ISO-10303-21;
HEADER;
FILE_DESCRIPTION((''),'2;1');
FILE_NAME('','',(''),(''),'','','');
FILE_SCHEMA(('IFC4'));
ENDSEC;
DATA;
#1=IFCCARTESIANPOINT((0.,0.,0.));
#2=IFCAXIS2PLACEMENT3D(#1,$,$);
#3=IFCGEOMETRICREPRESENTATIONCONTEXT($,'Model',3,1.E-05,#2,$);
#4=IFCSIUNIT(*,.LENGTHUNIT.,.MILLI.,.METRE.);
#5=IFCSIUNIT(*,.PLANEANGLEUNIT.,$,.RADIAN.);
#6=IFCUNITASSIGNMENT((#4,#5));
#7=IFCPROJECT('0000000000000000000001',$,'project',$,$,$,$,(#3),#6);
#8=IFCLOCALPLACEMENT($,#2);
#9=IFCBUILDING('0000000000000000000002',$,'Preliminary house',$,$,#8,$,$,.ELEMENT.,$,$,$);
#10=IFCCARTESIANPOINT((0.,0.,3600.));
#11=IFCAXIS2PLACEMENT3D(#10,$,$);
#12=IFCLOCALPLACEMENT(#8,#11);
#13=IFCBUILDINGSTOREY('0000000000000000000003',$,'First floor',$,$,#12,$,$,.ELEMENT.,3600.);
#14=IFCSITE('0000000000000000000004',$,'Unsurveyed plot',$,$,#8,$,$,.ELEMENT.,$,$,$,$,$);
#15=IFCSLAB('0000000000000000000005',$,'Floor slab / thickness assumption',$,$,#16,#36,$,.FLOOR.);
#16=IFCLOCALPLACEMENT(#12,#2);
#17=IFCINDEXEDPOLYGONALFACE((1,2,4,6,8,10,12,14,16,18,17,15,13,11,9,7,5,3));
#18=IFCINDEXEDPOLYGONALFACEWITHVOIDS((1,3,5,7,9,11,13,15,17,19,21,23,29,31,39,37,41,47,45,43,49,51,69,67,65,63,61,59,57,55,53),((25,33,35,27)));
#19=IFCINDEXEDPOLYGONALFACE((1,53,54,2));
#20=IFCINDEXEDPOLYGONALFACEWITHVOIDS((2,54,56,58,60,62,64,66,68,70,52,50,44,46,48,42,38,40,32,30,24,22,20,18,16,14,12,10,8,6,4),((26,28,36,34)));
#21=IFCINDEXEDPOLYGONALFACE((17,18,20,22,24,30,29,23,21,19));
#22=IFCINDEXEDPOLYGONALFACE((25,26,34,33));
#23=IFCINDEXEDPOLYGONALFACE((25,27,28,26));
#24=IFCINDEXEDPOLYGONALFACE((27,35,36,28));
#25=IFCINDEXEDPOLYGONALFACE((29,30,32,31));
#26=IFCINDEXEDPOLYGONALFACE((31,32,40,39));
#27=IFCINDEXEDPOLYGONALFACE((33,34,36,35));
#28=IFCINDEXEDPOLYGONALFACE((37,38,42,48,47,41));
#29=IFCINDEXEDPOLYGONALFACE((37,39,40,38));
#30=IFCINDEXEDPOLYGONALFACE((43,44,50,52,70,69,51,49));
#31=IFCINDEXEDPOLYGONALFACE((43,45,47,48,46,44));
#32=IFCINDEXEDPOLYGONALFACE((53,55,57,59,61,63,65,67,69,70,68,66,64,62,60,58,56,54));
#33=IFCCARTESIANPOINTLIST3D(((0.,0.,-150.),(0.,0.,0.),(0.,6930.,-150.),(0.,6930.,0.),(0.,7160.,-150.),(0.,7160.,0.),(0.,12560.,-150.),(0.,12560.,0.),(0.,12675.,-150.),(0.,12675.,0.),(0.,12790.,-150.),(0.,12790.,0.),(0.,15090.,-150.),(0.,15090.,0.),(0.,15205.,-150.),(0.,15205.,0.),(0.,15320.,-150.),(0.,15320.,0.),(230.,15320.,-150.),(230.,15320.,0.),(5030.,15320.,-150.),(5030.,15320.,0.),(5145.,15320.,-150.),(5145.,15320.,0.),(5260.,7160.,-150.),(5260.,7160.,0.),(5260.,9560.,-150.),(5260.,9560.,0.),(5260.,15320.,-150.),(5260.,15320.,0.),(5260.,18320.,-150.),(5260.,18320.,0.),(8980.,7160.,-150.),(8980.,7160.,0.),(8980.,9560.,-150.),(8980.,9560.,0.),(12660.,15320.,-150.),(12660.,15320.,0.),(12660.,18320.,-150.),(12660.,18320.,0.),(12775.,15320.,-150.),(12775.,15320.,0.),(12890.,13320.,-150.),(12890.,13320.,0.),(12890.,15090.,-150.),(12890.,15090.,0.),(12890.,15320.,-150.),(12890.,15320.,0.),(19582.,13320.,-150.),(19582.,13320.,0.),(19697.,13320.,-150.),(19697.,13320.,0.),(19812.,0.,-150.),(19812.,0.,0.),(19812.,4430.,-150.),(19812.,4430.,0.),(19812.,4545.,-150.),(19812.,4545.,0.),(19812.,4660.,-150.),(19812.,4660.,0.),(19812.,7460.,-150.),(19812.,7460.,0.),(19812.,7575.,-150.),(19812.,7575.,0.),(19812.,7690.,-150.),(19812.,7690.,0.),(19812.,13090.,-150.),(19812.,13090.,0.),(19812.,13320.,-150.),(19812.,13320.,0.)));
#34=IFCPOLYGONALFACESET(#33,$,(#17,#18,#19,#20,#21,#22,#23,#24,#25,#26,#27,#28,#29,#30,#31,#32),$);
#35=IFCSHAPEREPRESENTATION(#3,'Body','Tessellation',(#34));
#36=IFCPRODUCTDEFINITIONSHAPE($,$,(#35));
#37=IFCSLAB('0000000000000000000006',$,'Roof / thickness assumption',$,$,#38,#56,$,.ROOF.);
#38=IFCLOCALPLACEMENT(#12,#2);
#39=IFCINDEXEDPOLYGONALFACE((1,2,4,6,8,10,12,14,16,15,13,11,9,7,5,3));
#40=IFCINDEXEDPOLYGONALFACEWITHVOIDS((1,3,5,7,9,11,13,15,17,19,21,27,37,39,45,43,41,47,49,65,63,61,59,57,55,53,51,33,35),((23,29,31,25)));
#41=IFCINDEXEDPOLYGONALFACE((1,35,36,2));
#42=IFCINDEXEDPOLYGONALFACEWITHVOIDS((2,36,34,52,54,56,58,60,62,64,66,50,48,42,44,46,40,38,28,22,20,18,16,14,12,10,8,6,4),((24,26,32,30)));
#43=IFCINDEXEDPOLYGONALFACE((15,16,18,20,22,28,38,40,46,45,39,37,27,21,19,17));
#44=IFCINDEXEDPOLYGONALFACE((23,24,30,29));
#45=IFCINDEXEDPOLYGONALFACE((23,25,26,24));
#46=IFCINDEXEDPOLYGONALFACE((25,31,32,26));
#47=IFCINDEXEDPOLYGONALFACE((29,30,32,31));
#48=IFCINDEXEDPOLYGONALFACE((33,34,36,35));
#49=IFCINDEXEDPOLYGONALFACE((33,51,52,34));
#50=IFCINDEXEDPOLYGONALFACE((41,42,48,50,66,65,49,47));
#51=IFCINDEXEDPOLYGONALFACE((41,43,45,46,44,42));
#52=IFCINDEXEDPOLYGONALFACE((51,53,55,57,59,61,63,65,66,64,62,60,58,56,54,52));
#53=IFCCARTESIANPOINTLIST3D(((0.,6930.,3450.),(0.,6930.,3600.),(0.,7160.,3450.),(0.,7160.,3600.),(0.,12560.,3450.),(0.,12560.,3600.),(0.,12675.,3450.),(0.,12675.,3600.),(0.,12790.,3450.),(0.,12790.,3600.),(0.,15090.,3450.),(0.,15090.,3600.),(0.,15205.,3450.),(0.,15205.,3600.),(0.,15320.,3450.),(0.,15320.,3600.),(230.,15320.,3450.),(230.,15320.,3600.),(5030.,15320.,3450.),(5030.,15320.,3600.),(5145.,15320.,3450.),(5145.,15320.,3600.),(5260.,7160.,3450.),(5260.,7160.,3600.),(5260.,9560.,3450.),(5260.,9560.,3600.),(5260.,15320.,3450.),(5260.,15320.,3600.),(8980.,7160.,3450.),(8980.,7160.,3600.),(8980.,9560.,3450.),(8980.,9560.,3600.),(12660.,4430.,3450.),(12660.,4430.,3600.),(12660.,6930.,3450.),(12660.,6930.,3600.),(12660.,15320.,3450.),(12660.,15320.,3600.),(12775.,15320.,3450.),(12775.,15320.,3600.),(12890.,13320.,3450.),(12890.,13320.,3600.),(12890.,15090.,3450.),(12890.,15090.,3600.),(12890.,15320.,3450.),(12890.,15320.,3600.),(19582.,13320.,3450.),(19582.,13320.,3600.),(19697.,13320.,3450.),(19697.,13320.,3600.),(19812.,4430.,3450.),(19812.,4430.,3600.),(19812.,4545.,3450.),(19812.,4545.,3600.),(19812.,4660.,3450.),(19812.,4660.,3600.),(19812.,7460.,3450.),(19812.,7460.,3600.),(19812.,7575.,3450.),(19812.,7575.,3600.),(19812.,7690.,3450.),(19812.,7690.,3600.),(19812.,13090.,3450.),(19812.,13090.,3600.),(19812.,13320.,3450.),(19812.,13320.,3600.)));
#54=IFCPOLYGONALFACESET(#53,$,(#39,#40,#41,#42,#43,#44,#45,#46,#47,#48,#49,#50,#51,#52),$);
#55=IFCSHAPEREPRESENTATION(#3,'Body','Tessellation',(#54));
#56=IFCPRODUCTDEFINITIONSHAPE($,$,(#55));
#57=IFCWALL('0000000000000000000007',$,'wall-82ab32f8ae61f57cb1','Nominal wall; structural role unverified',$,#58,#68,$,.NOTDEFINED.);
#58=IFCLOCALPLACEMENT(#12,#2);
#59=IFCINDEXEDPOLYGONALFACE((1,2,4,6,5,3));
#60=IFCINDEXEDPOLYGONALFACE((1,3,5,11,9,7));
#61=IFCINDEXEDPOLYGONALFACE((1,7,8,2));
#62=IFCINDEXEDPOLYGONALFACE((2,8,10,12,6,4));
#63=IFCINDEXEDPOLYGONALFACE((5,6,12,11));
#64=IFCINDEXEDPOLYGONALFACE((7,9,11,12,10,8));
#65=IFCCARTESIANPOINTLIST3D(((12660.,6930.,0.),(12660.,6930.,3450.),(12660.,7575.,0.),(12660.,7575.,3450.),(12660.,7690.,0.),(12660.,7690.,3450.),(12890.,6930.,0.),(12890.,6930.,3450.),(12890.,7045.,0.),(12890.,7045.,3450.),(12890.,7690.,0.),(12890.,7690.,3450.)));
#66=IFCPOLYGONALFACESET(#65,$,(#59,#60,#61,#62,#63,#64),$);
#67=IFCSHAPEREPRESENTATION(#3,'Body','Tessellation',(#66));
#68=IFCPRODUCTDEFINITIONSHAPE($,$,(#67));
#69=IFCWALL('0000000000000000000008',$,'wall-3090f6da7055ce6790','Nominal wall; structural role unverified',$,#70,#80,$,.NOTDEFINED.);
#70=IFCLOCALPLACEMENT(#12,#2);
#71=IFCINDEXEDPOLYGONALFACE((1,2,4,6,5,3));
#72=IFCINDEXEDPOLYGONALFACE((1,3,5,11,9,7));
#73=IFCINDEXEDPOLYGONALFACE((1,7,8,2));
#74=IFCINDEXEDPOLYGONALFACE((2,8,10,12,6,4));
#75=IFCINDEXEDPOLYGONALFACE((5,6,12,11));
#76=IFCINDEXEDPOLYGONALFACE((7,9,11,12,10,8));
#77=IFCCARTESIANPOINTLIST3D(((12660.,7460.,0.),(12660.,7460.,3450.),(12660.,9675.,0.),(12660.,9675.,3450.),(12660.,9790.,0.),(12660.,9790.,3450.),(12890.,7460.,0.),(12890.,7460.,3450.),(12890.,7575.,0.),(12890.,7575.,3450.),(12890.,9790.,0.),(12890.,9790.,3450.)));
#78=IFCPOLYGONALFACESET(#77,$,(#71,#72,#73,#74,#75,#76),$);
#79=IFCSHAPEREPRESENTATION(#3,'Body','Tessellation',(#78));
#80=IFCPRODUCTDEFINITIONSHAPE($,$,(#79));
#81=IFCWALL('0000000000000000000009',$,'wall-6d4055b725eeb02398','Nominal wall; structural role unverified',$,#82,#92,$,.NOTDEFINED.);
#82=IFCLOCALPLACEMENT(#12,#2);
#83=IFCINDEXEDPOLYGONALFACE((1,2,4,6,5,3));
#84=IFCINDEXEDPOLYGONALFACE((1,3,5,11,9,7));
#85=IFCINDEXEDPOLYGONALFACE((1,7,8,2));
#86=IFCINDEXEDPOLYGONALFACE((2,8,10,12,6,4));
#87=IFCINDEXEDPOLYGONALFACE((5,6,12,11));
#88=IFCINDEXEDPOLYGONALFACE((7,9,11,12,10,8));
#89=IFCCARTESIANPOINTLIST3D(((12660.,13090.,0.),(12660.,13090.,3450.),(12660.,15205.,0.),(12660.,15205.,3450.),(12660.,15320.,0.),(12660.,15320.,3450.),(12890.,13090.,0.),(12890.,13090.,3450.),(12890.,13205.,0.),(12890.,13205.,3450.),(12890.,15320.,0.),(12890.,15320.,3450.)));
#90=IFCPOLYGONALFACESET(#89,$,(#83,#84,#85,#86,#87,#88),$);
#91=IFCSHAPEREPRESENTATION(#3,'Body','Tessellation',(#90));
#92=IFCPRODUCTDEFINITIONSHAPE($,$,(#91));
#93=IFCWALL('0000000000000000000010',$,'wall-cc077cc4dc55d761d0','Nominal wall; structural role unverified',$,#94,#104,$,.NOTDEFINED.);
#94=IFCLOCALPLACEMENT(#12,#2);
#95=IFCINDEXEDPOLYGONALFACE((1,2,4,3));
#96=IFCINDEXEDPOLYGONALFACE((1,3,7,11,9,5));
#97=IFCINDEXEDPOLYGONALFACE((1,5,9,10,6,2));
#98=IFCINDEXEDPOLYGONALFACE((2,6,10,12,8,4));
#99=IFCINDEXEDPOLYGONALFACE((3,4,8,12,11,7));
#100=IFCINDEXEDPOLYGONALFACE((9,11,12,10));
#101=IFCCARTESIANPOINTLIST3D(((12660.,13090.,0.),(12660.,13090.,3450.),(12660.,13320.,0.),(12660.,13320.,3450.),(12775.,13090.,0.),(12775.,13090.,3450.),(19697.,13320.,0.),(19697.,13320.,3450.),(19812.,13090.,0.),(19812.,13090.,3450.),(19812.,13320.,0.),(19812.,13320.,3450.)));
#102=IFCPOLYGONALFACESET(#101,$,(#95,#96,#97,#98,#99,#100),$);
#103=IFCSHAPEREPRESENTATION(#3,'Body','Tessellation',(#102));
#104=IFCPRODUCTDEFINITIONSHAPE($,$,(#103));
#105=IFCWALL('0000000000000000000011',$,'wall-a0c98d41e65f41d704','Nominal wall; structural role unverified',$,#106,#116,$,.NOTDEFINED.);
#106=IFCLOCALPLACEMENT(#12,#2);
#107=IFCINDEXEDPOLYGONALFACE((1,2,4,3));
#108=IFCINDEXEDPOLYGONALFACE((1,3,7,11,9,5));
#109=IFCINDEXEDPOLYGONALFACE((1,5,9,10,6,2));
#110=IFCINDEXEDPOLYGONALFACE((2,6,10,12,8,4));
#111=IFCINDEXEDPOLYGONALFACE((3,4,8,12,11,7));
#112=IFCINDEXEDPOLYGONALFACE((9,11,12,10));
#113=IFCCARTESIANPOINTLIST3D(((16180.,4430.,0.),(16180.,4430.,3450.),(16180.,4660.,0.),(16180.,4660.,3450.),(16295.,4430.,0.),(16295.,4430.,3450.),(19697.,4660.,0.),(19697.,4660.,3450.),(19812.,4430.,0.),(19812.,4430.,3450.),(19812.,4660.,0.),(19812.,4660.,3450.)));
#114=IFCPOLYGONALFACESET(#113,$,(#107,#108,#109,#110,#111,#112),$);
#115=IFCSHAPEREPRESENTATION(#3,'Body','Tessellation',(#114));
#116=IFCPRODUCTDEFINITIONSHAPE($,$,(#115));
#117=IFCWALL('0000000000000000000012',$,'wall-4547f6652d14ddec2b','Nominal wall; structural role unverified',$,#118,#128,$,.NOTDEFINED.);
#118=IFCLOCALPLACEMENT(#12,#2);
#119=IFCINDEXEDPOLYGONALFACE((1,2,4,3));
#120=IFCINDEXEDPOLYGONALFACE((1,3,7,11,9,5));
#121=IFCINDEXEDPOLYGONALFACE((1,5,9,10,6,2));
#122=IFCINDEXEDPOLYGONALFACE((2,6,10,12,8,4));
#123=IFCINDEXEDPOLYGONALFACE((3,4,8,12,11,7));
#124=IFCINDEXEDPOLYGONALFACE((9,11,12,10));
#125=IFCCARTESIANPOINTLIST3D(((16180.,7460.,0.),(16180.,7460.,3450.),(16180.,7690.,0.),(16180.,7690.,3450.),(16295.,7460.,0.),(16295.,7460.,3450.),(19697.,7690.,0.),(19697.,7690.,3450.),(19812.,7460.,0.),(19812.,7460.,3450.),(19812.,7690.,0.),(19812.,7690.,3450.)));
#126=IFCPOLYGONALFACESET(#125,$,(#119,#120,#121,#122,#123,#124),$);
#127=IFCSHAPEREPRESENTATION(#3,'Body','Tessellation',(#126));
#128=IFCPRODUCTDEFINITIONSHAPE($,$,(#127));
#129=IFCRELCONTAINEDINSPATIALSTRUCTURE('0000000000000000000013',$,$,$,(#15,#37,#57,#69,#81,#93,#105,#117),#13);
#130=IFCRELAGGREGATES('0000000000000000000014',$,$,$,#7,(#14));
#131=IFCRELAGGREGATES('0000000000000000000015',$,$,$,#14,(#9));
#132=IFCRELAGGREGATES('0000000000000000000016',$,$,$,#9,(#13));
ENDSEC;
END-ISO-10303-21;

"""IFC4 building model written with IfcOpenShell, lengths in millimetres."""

from ifc_helpers import new_model, si_unit, frame, origin, place, context, project, spatial, polyline, outline, extrude, element, save


model = new_model("IFC4")

# Units and contexts
model_context = context("Model", 3, precision=1e-05, world=origin())
ifc_project = project(units=[si_unit("LENGTHUNIT", "METRE", prefix="MILLI"), si_unit("PLANEANGLEUNIT", "RADIAN")], contexts=[model_context])

# Site, building, storey
placement_1 = place(None, origin())
site = spatial("IfcSite", under=ifc_project, at=placement_1, Name="Unsurveyed plot", CompositionType="ELEMENT")
building = spatial("IfcBuilding", under=site, at=placement_1, Name="Preliminary house", CompositionType="ELEMENT")
placement_2 = place(placement_1, frame((0.0, 0.0, 3600.0)))
storey = spatial("IfcBuildingStorey", under=building, at=placement_2, Name="First floor", CompositionType="ELEMENT", Elevation=3600.0)

# Slabs
element("IfcSlab", 1, at=placement_2, inside=storey, Name="Floor slab / thickness assumption", PredefinedType="FLOOR", context=model_context, shape_type="SweptSolid", body=[
    extrude(outline(polyline([(0.0, 7160.0), (0.0, 12560.0), (0.0, 12675.0), (0.0, 12790.0), (0.0, 15090.0), (0.0, 15205.0), (0.0, 15320.0), (230.0, 15320.0), (5030.0, 15320.0), (5145.0, 15320.0), (5260.0, 15320.0), (5260.0, 18320.0), (12660.0, 18320.0), (12660.0, 15320.0), (12775.0, 15320.0), (12890.0, 15320.0), (12890.0, 15090.0), (12890.0, 13320.0), (19582.0, 13320.0), (19697.0, 13320.0), (19812.0, 13320.0), (19812.0, 13090.0), (19812.0, 7690.0), (19812.0, 7575.0), (19812.0, 7460.0), (19812.0, 4660.0), (19812.0, 4545.0), (19812.0, 4430.0), (19812.0, 0.0), (0.0, 0.0), (0.0, 6930.0), (0.0, 7160.0)]), holes=[polyline([(5260.0, 9560.0), (5260.0, 7160.0), (8980.0, 7160.0), (8980.0, 9560.0), (5260.0, 9560.0)])]), frame((0.0, 0.0, -150.0)), (0.0, 0.0, 1.0), 150.0),
])
element("IfcSlab", 2, at=placement_2, inside=storey, Name="Roof / thickness assumption", PredefinedType="ROOF", context=model_context, shape_type="SweptSolid", body=[
    extrude(outline(polyline([(0.0, 12675.0), (0.0, 12790.0), (0.0, 15090.0), (0.0, 15205.0), (0.0, 15320.0), (230.0, 15320.0), (5030.0, 15320.0), (5145.0, 15320.0), (5260.0, 15320.0), (12660.0, 15320.0), (12775.0, 15320.0), (12890.0, 15320.0), (12890.0, 15090.0), (12890.0, 13320.0), (19582.0, 13320.0), (19697.0, 13320.0), (19812.0, 13320.0), (19812.0, 13090.0), (19812.0, 7690.0), (19812.0, 7575.0), (19812.0, 7460.0), (19812.0, 4660.0), (19812.0, 4545.0), (19812.0, 4430.0), (12660.0, 4430.0), (12660.0, 6930.0), (0.0, 6930.0), (0.0, 7160.0), (0.0, 12560.0), (0.0, 12675.0)]), holes=[polyline([(5260.0, 9560.0), (5260.0, 7160.0), (8980.0, 7160.0), (8980.0, 9560.0), (5260.0, 9560.0)])]), frame((0.0, 0.0, 3450.0)), (0.0, 0.0, 1.0), 150.0),
])

# Walls
element("IfcWall", 3, at=placement_2, inside=storey, Name="wall-82ab32f8ae61f57cb1", Description="Nominal wall; structural role unverified", PredefinedType="NOTDEFINED", context=model_context, shape_type="SweptSolid", body=[
    extrude(outline(polyline([(12660.0, 7575.0), (12660.0, 7690.0), (12890.0, 7690.0), (12890.0, 7045.0), (12890.0, 6930.0), (12660.0, 6930.0), (12660.0, 7575.0)])), origin(), (0.0, 0.0, 1.0), 3450.0),
])
element("IfcWall", 4, at=placement_2, inside=storey, Name="wall-3090f6da7055ce6790", Description="Nominal wall; structural role unverified", PredefinedType="NOTDEFINED", context=model_context, shape_type="SweptSolid", body=[
    extrude(outline(polyline([(12660.0, 9675.0), (12660.0, 9790.0), (12890.0, 9790.0), (12890.0, 7575.0), (12890.0, 7460.0), (12660.0, 7460.0), (12660.0, 9675.0)])), origin(), (0.0, 0.0, 1.0), 3450.0),
])

# Walls
element("IfcWall", 5, at=placement_2, inside=storey, Name="wall-6d4055b725eeb02398", Description="Nominal wall; structural role unverified", PredefinedType="NOTDEFINED", context=model_context, shape_type="SweptSolid", body=[
    extrude(outline(polyline([(12660.0, 15205.0), (12660.0, 15320.0), (12890.0, 15320.0), (12890.0, 13205.0), (12890.0, 13090.0), (12660.0, 13090.0), (12660.0, 15205.0)])), origin(), (0.0, 0.0, 1.0), 3450.0),
])
element("IfcWall", 6, at=placement_2, inside=storey, Name="wall-cc077cc4dc55d761d0", Description="Nominal wall; structural role unverified", PredefinedType="NOTDEFINED", context=model_context, shape_type="SweptSolid", body=[
    extrude(outline(polyline([(19697.0, 13320.0), (19812.0, 13320.0), (19812.0, 13090.0), (12775.0, 13090.0), (12660.0, 13090.0), (12660.0, 13320.0), (19697.0, 13320.0)])), origin(), (0.0, 0.0, 1.0), 3450.0),
])

# Walls
element("IfcWall", 7, at=placement_2, inside=storey, Name="wall-a0c98d41e65f41d704", Description="Nominal wall; structural role unverified", PredefinedType="NOTDEFINED", context=model_context, shape_type="SweptSolid", body=[
    extrude(outline(polyline([(19697.0, 4660.0), (19812.0, 4660.0), (19812.0, 4430.0), (16295.0, 4430.0), (16180.0, 4430.0), (16180.0, 4660.0), (19697.0, 4660.0)])), origin(), (0.0, 0.0, 1.0), 3450.0),
])
element("IfcWall", 8, at=placement_2, inside=storey, Name="wall-4547f6652d14ddec2b", Description="Nominal wall; structural role unverified", PredefinedType="NOTDEFINED", context=model_context, shape_type="SweptSolid", body=[
    extrude(outline(polyline([(19697.0, 7690.0), (19812.0, 7690.0), (19812.0, 7460.0), (16295.0, 7460.0), (16180.0, 7460.0), (16180.0, 7690.0), (19697.0, 7690.0)])), origin(), (0.0, 0.0, 1.0), 3450.0),
])

save(model, "model.ifc")
